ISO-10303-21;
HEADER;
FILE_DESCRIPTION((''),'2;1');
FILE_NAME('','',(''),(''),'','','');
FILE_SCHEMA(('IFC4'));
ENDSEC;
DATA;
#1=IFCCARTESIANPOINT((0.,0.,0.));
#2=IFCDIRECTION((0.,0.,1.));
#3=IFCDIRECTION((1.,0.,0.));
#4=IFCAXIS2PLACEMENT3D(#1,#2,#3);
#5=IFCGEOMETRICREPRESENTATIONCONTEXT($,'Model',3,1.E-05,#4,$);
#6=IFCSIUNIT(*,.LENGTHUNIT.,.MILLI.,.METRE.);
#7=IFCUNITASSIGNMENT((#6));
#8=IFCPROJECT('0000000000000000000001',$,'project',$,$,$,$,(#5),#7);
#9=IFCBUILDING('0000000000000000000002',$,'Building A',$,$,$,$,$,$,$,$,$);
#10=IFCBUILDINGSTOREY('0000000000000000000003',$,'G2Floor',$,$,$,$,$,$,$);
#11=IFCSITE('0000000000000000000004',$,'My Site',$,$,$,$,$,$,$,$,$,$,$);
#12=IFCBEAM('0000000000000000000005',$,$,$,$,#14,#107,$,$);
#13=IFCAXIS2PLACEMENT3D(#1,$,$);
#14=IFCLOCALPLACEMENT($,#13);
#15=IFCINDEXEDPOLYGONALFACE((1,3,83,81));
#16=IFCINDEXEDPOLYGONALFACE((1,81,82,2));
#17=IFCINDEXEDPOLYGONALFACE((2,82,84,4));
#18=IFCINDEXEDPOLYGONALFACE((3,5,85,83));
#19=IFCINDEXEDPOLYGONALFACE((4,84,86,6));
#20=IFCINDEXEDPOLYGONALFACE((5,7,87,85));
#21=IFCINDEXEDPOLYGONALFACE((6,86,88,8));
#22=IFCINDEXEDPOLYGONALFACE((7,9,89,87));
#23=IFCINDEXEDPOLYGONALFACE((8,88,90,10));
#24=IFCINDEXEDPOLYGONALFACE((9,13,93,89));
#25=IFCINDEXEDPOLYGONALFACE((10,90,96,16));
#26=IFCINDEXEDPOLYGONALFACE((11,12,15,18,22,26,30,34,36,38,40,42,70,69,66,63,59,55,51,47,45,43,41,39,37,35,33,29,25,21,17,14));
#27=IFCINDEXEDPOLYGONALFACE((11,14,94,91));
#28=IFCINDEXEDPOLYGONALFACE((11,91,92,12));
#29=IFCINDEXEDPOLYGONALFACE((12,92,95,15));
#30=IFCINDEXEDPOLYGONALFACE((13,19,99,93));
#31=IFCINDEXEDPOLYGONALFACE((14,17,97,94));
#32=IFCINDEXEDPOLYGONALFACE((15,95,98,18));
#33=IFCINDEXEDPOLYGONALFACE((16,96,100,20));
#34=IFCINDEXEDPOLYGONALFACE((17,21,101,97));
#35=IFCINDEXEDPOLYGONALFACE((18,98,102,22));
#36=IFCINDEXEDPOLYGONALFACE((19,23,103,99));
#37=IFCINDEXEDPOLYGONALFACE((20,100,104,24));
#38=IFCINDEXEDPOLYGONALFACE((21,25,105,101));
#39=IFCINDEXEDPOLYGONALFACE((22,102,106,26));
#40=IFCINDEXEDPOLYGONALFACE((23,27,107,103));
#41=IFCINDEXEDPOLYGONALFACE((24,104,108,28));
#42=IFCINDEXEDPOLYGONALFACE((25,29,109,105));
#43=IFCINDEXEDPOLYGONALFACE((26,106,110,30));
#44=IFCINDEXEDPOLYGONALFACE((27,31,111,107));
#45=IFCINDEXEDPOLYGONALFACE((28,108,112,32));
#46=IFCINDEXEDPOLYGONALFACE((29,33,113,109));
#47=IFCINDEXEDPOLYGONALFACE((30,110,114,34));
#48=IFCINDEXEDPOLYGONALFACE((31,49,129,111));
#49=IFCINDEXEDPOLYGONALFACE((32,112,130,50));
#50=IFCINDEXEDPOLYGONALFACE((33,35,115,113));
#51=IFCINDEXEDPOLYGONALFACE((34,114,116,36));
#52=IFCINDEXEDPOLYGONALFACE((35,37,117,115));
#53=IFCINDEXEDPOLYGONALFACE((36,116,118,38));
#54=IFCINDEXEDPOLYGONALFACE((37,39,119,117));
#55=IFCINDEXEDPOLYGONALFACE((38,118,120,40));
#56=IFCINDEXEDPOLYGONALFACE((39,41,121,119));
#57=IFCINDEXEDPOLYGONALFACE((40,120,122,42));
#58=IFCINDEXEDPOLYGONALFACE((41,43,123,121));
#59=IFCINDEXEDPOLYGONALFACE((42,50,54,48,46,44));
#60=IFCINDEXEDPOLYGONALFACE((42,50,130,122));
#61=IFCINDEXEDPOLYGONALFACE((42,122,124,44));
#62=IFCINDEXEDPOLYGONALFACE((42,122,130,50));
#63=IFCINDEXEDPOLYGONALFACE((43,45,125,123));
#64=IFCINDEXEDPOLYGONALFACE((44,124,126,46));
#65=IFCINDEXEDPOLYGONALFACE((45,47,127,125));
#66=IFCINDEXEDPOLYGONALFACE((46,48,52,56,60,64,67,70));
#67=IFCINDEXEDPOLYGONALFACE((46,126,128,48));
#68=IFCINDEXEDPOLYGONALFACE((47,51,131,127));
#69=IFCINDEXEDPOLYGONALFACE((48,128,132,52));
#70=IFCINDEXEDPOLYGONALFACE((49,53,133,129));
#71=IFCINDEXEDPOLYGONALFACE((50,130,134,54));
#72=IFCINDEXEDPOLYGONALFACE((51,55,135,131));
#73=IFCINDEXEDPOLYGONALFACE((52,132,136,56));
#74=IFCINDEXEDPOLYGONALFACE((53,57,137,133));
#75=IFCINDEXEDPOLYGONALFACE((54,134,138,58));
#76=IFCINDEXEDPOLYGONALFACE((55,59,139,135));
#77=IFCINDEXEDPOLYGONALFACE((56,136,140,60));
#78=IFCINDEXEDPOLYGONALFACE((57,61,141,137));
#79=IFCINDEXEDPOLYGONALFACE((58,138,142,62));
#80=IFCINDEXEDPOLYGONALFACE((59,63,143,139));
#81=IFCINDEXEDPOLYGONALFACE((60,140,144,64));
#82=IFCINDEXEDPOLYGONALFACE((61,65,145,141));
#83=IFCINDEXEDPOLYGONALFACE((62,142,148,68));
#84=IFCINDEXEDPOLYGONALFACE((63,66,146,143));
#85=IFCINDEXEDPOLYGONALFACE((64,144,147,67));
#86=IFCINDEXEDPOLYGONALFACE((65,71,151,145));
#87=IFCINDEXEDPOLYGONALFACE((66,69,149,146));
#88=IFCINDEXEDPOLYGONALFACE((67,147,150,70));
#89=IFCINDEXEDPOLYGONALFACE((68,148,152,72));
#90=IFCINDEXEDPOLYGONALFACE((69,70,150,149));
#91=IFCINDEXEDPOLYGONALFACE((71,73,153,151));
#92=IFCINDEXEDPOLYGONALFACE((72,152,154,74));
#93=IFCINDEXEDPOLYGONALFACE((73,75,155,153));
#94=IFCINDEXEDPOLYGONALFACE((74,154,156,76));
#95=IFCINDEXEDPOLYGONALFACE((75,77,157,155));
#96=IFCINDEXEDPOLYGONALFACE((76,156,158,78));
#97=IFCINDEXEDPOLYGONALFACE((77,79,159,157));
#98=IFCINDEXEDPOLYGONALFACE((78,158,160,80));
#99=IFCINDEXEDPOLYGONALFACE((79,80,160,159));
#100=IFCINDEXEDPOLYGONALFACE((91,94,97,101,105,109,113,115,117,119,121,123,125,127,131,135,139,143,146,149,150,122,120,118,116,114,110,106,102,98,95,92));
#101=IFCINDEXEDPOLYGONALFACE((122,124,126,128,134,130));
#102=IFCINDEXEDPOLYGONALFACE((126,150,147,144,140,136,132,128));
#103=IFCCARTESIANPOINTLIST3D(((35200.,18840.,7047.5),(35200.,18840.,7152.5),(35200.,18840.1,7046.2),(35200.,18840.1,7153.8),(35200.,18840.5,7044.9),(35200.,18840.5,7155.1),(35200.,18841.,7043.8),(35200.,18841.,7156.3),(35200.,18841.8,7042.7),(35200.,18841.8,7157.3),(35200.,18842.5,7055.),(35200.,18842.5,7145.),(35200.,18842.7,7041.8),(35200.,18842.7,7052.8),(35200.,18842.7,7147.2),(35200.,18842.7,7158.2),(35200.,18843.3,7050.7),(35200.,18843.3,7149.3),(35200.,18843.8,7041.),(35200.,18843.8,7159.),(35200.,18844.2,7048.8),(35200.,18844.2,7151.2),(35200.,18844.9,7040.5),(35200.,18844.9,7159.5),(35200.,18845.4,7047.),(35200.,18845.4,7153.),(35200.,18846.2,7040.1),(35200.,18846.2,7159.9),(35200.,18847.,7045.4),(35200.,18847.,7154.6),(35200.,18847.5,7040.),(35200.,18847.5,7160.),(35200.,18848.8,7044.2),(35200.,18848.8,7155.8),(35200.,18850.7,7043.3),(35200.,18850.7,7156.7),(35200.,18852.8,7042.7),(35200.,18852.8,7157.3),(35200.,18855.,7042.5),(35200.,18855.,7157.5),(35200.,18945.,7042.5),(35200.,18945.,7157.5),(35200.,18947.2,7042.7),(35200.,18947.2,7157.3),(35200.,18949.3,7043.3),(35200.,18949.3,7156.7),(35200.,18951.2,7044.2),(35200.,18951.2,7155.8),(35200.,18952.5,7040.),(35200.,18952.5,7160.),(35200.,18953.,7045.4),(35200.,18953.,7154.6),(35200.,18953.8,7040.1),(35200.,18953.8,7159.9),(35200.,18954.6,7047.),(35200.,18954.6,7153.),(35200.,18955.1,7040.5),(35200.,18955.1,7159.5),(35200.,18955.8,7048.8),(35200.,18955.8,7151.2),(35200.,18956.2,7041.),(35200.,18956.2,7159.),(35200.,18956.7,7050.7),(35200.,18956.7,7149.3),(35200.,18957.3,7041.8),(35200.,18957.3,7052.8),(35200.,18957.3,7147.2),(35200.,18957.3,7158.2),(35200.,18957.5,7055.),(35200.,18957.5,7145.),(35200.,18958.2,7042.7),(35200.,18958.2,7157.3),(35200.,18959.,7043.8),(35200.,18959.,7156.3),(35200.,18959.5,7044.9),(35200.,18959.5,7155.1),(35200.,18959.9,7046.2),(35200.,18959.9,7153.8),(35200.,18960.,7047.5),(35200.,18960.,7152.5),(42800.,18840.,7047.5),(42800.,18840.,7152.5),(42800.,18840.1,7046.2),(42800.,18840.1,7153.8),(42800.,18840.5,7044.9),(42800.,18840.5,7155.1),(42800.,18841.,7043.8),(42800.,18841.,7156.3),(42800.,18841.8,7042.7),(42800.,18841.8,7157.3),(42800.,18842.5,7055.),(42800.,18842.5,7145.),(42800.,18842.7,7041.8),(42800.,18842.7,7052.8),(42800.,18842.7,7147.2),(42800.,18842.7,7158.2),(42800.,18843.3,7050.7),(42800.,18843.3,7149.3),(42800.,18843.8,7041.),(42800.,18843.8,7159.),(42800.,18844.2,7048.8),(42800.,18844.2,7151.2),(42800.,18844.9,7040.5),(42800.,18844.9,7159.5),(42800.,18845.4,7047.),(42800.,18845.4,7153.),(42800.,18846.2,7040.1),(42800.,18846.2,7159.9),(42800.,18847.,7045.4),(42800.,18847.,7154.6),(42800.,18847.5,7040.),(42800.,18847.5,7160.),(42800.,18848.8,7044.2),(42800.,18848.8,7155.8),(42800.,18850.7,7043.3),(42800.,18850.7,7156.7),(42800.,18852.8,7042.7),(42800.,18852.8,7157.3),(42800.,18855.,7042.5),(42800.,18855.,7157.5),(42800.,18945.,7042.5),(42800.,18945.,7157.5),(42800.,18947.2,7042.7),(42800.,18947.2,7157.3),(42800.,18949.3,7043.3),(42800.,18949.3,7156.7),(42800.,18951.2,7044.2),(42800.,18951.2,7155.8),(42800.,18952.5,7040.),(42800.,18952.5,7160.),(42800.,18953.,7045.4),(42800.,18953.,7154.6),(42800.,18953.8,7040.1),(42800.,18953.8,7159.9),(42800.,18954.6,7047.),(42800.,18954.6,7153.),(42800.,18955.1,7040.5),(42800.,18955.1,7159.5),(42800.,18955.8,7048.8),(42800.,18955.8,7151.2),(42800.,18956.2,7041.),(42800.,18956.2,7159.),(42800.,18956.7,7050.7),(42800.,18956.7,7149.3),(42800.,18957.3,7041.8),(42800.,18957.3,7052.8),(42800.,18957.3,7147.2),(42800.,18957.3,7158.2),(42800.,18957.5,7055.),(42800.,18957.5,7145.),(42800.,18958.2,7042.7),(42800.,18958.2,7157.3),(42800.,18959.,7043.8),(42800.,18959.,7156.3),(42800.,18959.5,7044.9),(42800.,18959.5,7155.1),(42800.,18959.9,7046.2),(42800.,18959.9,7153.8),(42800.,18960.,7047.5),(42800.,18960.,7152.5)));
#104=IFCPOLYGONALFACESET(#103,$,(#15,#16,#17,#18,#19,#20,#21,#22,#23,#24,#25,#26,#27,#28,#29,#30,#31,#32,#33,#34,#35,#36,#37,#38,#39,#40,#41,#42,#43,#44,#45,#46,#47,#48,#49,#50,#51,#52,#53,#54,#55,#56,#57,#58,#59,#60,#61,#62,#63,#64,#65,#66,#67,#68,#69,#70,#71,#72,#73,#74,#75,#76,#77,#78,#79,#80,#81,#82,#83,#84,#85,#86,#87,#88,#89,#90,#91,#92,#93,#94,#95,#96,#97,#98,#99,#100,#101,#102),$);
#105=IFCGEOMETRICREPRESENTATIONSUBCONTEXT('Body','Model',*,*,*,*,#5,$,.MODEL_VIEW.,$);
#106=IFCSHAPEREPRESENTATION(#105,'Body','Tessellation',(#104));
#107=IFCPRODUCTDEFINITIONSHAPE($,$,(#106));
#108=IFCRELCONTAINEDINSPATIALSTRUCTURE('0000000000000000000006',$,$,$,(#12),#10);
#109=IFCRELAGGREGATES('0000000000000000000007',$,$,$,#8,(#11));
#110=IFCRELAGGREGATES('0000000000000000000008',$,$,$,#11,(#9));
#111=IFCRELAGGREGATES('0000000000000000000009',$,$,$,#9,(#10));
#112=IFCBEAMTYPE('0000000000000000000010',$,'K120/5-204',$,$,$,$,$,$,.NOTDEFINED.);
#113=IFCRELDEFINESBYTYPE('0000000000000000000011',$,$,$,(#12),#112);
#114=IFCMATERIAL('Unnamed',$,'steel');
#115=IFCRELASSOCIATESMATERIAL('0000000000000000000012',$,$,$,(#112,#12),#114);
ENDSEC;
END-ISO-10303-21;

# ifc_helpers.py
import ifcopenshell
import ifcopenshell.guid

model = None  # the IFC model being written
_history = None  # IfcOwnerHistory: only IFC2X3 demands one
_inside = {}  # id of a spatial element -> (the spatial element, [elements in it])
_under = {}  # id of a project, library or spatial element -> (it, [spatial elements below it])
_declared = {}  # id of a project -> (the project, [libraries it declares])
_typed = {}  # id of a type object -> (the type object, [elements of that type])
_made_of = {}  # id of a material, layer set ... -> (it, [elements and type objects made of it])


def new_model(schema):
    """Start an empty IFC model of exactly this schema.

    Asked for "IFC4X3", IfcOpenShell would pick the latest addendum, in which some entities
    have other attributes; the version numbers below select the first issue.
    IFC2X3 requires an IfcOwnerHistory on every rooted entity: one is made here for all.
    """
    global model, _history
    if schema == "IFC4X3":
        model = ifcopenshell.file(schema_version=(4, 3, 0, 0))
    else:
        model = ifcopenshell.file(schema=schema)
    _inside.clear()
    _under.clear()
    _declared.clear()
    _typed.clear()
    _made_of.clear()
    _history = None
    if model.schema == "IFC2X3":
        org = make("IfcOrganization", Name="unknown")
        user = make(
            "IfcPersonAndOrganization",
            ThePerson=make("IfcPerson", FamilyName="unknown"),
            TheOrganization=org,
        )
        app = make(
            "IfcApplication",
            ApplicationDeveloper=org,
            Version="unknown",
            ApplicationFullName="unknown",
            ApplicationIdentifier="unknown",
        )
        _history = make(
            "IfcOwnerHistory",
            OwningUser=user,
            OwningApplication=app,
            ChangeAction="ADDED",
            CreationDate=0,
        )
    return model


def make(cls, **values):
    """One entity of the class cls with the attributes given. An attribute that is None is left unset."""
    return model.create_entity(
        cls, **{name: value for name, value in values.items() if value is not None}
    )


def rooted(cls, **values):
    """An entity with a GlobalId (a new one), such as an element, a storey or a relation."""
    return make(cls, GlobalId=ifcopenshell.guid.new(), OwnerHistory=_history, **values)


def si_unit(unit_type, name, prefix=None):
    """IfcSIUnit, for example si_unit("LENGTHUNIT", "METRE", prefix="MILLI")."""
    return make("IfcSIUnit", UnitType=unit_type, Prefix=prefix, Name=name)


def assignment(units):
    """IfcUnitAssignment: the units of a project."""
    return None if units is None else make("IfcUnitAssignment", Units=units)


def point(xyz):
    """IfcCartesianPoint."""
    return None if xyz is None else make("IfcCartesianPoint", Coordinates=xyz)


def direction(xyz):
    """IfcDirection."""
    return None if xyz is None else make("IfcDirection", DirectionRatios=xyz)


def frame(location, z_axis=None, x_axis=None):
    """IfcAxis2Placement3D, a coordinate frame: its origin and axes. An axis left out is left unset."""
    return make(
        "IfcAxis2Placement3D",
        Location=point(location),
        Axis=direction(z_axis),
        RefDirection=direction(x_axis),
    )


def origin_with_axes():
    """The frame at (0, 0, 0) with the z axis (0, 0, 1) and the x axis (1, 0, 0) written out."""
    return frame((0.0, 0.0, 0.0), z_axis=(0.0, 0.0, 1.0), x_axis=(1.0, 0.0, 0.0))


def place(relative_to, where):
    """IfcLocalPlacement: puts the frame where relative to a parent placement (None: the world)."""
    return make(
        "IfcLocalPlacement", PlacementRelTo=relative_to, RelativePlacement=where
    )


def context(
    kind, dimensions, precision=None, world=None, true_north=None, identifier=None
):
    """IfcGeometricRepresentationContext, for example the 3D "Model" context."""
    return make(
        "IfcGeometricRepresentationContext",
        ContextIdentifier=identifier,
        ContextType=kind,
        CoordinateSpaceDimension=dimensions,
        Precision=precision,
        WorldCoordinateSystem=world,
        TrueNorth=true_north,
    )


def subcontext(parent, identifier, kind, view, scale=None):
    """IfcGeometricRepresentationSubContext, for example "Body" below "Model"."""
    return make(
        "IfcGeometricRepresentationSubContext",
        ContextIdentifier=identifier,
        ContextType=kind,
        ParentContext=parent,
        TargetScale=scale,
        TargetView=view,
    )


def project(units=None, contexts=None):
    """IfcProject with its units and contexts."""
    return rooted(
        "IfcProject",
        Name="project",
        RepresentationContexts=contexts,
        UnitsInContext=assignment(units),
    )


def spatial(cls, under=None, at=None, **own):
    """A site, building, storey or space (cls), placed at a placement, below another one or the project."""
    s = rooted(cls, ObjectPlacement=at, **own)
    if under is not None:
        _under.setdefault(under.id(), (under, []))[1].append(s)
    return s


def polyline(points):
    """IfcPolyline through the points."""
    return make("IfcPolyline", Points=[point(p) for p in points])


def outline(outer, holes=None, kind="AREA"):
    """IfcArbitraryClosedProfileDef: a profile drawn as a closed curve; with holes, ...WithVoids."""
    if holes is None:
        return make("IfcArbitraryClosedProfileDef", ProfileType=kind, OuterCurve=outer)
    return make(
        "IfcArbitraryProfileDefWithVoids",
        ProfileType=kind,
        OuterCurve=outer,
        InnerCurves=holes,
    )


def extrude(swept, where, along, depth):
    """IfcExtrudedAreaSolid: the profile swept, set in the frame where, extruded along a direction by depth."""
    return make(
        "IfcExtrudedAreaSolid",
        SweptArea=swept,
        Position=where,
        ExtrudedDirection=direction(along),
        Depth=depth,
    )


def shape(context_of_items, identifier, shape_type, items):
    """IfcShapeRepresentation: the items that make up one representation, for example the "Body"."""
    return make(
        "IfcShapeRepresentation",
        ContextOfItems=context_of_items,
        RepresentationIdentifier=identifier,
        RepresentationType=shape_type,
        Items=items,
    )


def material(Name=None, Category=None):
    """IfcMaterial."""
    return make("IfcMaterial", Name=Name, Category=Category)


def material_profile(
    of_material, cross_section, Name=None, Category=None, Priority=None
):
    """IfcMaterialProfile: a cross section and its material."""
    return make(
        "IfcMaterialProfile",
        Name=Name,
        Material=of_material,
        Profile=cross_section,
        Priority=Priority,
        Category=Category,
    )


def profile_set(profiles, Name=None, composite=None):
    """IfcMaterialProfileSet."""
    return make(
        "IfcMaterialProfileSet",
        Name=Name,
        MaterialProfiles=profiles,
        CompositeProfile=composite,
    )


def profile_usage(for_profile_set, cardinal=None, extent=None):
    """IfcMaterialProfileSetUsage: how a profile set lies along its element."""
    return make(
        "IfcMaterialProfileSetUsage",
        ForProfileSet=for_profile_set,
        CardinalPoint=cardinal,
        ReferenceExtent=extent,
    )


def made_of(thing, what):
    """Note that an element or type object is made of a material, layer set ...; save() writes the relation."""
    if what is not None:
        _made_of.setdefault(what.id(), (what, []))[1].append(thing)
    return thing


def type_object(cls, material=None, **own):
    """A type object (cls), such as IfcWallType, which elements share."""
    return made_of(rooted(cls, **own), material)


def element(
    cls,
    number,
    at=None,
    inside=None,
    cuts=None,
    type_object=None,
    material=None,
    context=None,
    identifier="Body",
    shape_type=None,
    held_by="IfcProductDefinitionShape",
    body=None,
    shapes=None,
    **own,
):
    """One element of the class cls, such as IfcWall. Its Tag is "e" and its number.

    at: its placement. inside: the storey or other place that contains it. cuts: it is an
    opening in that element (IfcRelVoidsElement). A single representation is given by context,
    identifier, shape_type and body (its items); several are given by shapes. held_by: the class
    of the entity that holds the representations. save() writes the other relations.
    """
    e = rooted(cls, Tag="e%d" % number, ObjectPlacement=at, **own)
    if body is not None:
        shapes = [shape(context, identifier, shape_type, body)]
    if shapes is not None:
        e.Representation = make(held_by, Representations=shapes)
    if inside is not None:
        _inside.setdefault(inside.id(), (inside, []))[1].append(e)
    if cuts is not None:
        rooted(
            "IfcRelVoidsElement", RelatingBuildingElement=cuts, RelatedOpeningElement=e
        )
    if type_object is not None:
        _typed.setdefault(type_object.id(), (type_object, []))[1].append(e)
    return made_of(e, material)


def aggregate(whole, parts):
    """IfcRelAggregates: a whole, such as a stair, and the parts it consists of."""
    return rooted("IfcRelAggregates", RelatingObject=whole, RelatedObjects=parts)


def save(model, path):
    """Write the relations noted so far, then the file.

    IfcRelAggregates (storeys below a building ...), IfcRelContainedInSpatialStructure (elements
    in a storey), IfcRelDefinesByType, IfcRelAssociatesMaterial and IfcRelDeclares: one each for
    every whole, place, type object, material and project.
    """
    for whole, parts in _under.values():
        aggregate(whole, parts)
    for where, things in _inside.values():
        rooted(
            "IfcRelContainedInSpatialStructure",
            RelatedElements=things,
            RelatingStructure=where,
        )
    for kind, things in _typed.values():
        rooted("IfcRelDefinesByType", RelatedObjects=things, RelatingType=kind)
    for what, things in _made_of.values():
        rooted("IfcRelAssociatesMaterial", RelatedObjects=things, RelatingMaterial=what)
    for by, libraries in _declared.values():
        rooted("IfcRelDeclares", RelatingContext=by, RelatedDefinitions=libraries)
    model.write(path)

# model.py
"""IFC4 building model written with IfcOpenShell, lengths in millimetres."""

from ifc_helpers import new_model, si_unit, frame, origin_with_axes, place, context, subcontext, project, spatial, polyline, outline, extrude, material, material_profile, profile_set, profile_usage, type_object, element, save


model = new_model("IFC4")

# Units and contexts
model_context = context("Model", 3, precision=1e-05, world=origin_with_axes())
body_context = subcontext(model_context, "Body", "Model", "MODEL_VIEW")
ifc_project = project(units=[si_unit("LENGTHUNIT", "METRE", prefix="MILLI")], contexts=[model_context])

# Site, building, storey
site = spatial("IfcSite", under=ifc_project, Name="My Site")
building = spatial("IfcBuilding", under=site, Name="Building A")
storey = spatial("IfcBuildingStorey", under=building, Name="G2Floor")

# Beam
ifc_material_1 = material(Name="Unnamed", Category="steel")
ifc_material_profile_1 = material_profile(ifc_material_1, outline(polyline([(-52.5, -60.0), (52.5, -60.0), (52.5, -60.0), (53.8, -59.9), (53.8, -59.9), (55.1, -59.5), (55.1, -59.5), (56.2, -59.0), (56.2, -59.0), (57.3, -58.2), (57.3, -58.2), (58.2, -57.3), (58.2, -57.3), (59.0, -56.2), (59.0, -56.2), (59.5, -55.1), (59.5, -55.1), (59.9, -53.8), (59.9, -53.8), (60.0, -52.5), (60.0, -52.5), (60.0, 52.5), (60.0, 52.5), (59.9, 53.8), (59.9, 53.8), (59.5, 55.1), (59.5, 55.1), (59.0, 56.2), (59.0, 56.2), (58.2, 57.3), (58.2, 57.3), (57.3, 58.2), (57.3, 58.2), (56.2, 59.0), (56.2, 59.0), (55.1, 59.5), (55.1, 59.5), (53.8, 59.9), (53.8, 59.9), (52.5, 60.0), (52.5, 60.0), (-52.5, 60.0), (-52.5, 60.0), (-53.8, 59.9), (-53.8, 59.9), (-55.1, 59.5), (-55.1, 59.5), (-56.2, 59.0), (-56.2, 59.0), (-57.3, 58.2), (-57.3, 58.2), (-58.2, 57.3), (-58.2, 57.3), (-59.0, 56.2), (-59.0, 56.2), (-59.5, 55.1), (-59.5, 55.1), (-59.9, 53.8), (-59.9, 53.8), (-60.0, 52.5), (-60.0, 52.5), (-60.0, -52.5), (-60.0, -52.5), (-59.9, -53.8), (-59.9, -53.8), (-59.5, -55.1), (-59.5, -55.1), (-59.0, -56.2), (-59.0, -56.2), (-58.2, -57.3), (-58.2, -57.3), (-57.3, -58.2), (-57.3, -58.2), (-56.2, -59.0), (-56.2, -59.0), (-55.1, -59.5), (-55.1, -59.5), (-53.8, -59.9), (-53.8, -59.9), (-52.5, -60.0), (-52.5, -60.0), (-45.0, -57.5), (-45.0, -57.5), (45.0, -57.5), (45.0, -57.5), (47.2, -57.3), (47.2, -57.3), (49.3, -56.7), (49.3, -56.7), (51.2, -55.8), (51.2, -55.8), (53.0, -54.6), (53.0, -54.6), (54.6, -53.0), (54.6, -53.0), (55.8, -51.2), (55.8, -51.2), (56.7, -49.3), (56.7, -49.3), (57.3, -47.2), (57.3, -47.2), (57.5, -45.0), (57.5, -45.0), (57.5, 45.0), (57.5, 45.0), (57.3, 47.2), (57.3, 47.2), (56.7, 49.3), (56.7, 49.3), (55.8, 51.2), (55.8, 51.2), (54.6, 53.0), (54.6, 53.0), (53.0, 54.6), (53.0, 54.6), (51.2, 55.8), (51.2, 55.8), (49.3, 56.7), (49.3, 56.7), (47.2, 57.3), (47.2, 57.3), (45.0, 57.5), (45.0, 57.5), (-45.0, 57.5), (-45.0, 57.5), (-47.2, 57.3), (-47.2, 57.3), (-49.3, 56.7), (-49.3, 56.7), (-51.2, 55.8), (-51.2, 55.8), (-53.0, 54.6), (-53.0, 54.6), (-54.6, 53.0), (-54.6, 53.0), (-55.8, 51.2), (-55.8, 51.2), (-56.7, 49.3), (-56.7, 49.3), (-57.3, 47.2), (-57.3, 47.2), (-57.5, 45.0), (-57.5, 45.0), (-57.5, -45.0), (-57.5, -45.0), (-57.3, -47.2), (-57.3, -47.2), (-56.7, -49.3), (-56.7, -49.3), (-55.8, -51.2), (-55.8, -51.2), (-54.6, -53.0), (-54.6, -53.0), (-53.0, -54.6), (-53.0, -54.6), (-51.2, -55.8), (-51.2, -55.8), (-49.3, -56.7), (-49.3, -56.7), (-47.2, -57.3), (-47.2, -57.3), (-45.0, -57.5), (-45.0, -57.5), (-52.5, -60.0)])))
ifc_profile_set_1 = profile_set([ifc_material_profile_1], Name="K120/5-204")
ifc_profile_usage_1 = profile_usage(ifc_profile_set_1)
beam_type_1 = type_object("IfcBeamType", Name="K120/5-204", PredefinedType="NOTDEFINED", material=ifc_profile_set_1)
beam_1_placement = place(None, frame((35200.0, 18900.0, 7100.0), z_axis=(1.0, 0.0, 0.0), x_axis=(0.0, -1.0, 0.0)))
element("IfcBeam", 1, at=beam_1_placement, inside=storey, type_object=beam_type_1, material=ifc_profile_usage_1, context=body_context, shape_type="SweptSolid", body=[
    extrude(outline(polyline([(-52.5, -60.0), (52.5, -60.0), (52.5, -60.0), (53.8, -59.9), (53.8, -59.9), (55.1, -59.5), (55.1, -59.5), (56.2, -59.0), (56.2, -59.0), (57.3, -58.2), (57.3, -58.2), (58.2, -57.3), (58.2, -57.3), (59.0, -56.2), (59.0, -56.2), (59.5, -55.1), (59.5, -55.1), (59.9, -53.8), (59.9, -53.8), (60.0, -52.5), (60.0, -52.5), (60.0, 52.5), (60.0, 52.5), (59.9, 53.8), (59.9, 53.8), (59.5, 55.1), (59.5, 55.1), (59.0, 56.2), (59.0, 56.2), (58.2, 57.3), (58.2, 57.3), (57.3, 58.2), (57.3, 58.2), (56.2, 59.0), (56.2, 59.0), (55.1, 59.5), (55.1, 59.5), (53.8, 59.9), (53.8, 59.9), (52.5, 60.0), (52.5, 60.0), (-52.5, 60.0), (-52.5, 60.0), (-53.8, 59.9), (-53.8, 59.9), (-55.1, 59.5), (-55.1, 59.5), (-56.2, 59.0), (-56.2, 59.0), (-57.3, 58.2), (-57.3, 58.2), (-58.2, 57.3), (-58.2, 57.3), (-59.0, 56.2), (-59.0, 56.2), (-59.5, 55.1), (-59.5, 55.1), (-59.9, 53.8), (-59.9, 53.8), (-60.0, 52.5), (-60.0, 52.5), (-60.0, -52.5), (-60.0, -52.5), (-59.9, -53.8), (-59.9, -53.8), (-59.5, -55.1), (-59.5, -55.1), (-59.0, -56.2), (-59.0, -56.2), (-58.2, -57.3), (-58.2, -57.3), (-57.3, -58.2), (-57.3, -58.2), (-56.2, -59.0), (-56.2, -59.0), (-55.1, -59.5), (-55.1, -59.5), (-53.8, -59.9), (-53.8, -59.9), (-52.5, -60.0), (-52.5, -60.0), (-45.0, -57.5), (-45.0, -57.5), (45.0, -57.5), (45.0, -57.5), (47.2, -57.3), (47.2, -57.3), (49.3, -56.7), (49.3, -56.7), (51.2, -55.8), (51.2, -55.8), (53.0, -54.6), (53.0, -54.6), (54.6, -53.0), (54.6, -53.0), (55.8, -51.2), (55.8, -51.2), (56.7, -49.3), (56.7, -49.3), (57.3, -47.2), (57.3, -47.2), (57.5, -45.0), (57.5, -45.0), (57.5, 45.0), (57.5, 45.0), (57.3, 47.2), (57.3, 47.2), (56.7, 49.3), (56.7, 49.3), (55.8, 51.2), (55.8, 51.2), (54.6, 53.0), (54.6, 53.0), (53.0, 54.6), (53.0, 54.6), (51.2, 55.8), (51.2, 55.8), (49.3, 56.7), (49.3, 56.7), (47.2, 57.3), (47.2, 57.3), (45.0, 57.5), (45.0, 57.5), (-45.0, 57.5), (-45.0, 57.5), (-47.2, 57.3), (-47.2, 57.3), (-49.3, 56.7), (-49.3, 56.7), (-51.2, 55.8), (-51.2, 55.8), (-53.0, 54.6), (-53.0, 54.6), (-54.6, 53.0), (-54.6, 53.0), (-55.8, 51.2), (-55.8, 51.2), (-56.7, 49.3), (-56.7, 49.3), (-57.3, 47.2), (-57.3, 47.2), (-57.5, 45.0), (-57.5, 45.0), (-57.5, -45.0), (-57.5, -45.0), (-57.3, -47.2), (-57.3, -47.2), (-56.7, -49.3), (-56.7, -49.3), (-55.8, -51.2), (-55.8, -51.2), (-54.6, -53.0), (-54.6, -53.0), (-53.0, -54.6), (-53.0, -54.6), (-51.2, -55.8), (-51.2, -55.8), (-49.3, -56.7), (-49.3, -56.7), (-47.2, -57.3), (-47.2, -57.3), (-45.0, -57.5), (-45.0, -57.5), (-52.5, -60.0)])), origin_with_axes(), (0.0, 0.0, 1.0), 7600.0),
])

save(model, "model.ifc")
